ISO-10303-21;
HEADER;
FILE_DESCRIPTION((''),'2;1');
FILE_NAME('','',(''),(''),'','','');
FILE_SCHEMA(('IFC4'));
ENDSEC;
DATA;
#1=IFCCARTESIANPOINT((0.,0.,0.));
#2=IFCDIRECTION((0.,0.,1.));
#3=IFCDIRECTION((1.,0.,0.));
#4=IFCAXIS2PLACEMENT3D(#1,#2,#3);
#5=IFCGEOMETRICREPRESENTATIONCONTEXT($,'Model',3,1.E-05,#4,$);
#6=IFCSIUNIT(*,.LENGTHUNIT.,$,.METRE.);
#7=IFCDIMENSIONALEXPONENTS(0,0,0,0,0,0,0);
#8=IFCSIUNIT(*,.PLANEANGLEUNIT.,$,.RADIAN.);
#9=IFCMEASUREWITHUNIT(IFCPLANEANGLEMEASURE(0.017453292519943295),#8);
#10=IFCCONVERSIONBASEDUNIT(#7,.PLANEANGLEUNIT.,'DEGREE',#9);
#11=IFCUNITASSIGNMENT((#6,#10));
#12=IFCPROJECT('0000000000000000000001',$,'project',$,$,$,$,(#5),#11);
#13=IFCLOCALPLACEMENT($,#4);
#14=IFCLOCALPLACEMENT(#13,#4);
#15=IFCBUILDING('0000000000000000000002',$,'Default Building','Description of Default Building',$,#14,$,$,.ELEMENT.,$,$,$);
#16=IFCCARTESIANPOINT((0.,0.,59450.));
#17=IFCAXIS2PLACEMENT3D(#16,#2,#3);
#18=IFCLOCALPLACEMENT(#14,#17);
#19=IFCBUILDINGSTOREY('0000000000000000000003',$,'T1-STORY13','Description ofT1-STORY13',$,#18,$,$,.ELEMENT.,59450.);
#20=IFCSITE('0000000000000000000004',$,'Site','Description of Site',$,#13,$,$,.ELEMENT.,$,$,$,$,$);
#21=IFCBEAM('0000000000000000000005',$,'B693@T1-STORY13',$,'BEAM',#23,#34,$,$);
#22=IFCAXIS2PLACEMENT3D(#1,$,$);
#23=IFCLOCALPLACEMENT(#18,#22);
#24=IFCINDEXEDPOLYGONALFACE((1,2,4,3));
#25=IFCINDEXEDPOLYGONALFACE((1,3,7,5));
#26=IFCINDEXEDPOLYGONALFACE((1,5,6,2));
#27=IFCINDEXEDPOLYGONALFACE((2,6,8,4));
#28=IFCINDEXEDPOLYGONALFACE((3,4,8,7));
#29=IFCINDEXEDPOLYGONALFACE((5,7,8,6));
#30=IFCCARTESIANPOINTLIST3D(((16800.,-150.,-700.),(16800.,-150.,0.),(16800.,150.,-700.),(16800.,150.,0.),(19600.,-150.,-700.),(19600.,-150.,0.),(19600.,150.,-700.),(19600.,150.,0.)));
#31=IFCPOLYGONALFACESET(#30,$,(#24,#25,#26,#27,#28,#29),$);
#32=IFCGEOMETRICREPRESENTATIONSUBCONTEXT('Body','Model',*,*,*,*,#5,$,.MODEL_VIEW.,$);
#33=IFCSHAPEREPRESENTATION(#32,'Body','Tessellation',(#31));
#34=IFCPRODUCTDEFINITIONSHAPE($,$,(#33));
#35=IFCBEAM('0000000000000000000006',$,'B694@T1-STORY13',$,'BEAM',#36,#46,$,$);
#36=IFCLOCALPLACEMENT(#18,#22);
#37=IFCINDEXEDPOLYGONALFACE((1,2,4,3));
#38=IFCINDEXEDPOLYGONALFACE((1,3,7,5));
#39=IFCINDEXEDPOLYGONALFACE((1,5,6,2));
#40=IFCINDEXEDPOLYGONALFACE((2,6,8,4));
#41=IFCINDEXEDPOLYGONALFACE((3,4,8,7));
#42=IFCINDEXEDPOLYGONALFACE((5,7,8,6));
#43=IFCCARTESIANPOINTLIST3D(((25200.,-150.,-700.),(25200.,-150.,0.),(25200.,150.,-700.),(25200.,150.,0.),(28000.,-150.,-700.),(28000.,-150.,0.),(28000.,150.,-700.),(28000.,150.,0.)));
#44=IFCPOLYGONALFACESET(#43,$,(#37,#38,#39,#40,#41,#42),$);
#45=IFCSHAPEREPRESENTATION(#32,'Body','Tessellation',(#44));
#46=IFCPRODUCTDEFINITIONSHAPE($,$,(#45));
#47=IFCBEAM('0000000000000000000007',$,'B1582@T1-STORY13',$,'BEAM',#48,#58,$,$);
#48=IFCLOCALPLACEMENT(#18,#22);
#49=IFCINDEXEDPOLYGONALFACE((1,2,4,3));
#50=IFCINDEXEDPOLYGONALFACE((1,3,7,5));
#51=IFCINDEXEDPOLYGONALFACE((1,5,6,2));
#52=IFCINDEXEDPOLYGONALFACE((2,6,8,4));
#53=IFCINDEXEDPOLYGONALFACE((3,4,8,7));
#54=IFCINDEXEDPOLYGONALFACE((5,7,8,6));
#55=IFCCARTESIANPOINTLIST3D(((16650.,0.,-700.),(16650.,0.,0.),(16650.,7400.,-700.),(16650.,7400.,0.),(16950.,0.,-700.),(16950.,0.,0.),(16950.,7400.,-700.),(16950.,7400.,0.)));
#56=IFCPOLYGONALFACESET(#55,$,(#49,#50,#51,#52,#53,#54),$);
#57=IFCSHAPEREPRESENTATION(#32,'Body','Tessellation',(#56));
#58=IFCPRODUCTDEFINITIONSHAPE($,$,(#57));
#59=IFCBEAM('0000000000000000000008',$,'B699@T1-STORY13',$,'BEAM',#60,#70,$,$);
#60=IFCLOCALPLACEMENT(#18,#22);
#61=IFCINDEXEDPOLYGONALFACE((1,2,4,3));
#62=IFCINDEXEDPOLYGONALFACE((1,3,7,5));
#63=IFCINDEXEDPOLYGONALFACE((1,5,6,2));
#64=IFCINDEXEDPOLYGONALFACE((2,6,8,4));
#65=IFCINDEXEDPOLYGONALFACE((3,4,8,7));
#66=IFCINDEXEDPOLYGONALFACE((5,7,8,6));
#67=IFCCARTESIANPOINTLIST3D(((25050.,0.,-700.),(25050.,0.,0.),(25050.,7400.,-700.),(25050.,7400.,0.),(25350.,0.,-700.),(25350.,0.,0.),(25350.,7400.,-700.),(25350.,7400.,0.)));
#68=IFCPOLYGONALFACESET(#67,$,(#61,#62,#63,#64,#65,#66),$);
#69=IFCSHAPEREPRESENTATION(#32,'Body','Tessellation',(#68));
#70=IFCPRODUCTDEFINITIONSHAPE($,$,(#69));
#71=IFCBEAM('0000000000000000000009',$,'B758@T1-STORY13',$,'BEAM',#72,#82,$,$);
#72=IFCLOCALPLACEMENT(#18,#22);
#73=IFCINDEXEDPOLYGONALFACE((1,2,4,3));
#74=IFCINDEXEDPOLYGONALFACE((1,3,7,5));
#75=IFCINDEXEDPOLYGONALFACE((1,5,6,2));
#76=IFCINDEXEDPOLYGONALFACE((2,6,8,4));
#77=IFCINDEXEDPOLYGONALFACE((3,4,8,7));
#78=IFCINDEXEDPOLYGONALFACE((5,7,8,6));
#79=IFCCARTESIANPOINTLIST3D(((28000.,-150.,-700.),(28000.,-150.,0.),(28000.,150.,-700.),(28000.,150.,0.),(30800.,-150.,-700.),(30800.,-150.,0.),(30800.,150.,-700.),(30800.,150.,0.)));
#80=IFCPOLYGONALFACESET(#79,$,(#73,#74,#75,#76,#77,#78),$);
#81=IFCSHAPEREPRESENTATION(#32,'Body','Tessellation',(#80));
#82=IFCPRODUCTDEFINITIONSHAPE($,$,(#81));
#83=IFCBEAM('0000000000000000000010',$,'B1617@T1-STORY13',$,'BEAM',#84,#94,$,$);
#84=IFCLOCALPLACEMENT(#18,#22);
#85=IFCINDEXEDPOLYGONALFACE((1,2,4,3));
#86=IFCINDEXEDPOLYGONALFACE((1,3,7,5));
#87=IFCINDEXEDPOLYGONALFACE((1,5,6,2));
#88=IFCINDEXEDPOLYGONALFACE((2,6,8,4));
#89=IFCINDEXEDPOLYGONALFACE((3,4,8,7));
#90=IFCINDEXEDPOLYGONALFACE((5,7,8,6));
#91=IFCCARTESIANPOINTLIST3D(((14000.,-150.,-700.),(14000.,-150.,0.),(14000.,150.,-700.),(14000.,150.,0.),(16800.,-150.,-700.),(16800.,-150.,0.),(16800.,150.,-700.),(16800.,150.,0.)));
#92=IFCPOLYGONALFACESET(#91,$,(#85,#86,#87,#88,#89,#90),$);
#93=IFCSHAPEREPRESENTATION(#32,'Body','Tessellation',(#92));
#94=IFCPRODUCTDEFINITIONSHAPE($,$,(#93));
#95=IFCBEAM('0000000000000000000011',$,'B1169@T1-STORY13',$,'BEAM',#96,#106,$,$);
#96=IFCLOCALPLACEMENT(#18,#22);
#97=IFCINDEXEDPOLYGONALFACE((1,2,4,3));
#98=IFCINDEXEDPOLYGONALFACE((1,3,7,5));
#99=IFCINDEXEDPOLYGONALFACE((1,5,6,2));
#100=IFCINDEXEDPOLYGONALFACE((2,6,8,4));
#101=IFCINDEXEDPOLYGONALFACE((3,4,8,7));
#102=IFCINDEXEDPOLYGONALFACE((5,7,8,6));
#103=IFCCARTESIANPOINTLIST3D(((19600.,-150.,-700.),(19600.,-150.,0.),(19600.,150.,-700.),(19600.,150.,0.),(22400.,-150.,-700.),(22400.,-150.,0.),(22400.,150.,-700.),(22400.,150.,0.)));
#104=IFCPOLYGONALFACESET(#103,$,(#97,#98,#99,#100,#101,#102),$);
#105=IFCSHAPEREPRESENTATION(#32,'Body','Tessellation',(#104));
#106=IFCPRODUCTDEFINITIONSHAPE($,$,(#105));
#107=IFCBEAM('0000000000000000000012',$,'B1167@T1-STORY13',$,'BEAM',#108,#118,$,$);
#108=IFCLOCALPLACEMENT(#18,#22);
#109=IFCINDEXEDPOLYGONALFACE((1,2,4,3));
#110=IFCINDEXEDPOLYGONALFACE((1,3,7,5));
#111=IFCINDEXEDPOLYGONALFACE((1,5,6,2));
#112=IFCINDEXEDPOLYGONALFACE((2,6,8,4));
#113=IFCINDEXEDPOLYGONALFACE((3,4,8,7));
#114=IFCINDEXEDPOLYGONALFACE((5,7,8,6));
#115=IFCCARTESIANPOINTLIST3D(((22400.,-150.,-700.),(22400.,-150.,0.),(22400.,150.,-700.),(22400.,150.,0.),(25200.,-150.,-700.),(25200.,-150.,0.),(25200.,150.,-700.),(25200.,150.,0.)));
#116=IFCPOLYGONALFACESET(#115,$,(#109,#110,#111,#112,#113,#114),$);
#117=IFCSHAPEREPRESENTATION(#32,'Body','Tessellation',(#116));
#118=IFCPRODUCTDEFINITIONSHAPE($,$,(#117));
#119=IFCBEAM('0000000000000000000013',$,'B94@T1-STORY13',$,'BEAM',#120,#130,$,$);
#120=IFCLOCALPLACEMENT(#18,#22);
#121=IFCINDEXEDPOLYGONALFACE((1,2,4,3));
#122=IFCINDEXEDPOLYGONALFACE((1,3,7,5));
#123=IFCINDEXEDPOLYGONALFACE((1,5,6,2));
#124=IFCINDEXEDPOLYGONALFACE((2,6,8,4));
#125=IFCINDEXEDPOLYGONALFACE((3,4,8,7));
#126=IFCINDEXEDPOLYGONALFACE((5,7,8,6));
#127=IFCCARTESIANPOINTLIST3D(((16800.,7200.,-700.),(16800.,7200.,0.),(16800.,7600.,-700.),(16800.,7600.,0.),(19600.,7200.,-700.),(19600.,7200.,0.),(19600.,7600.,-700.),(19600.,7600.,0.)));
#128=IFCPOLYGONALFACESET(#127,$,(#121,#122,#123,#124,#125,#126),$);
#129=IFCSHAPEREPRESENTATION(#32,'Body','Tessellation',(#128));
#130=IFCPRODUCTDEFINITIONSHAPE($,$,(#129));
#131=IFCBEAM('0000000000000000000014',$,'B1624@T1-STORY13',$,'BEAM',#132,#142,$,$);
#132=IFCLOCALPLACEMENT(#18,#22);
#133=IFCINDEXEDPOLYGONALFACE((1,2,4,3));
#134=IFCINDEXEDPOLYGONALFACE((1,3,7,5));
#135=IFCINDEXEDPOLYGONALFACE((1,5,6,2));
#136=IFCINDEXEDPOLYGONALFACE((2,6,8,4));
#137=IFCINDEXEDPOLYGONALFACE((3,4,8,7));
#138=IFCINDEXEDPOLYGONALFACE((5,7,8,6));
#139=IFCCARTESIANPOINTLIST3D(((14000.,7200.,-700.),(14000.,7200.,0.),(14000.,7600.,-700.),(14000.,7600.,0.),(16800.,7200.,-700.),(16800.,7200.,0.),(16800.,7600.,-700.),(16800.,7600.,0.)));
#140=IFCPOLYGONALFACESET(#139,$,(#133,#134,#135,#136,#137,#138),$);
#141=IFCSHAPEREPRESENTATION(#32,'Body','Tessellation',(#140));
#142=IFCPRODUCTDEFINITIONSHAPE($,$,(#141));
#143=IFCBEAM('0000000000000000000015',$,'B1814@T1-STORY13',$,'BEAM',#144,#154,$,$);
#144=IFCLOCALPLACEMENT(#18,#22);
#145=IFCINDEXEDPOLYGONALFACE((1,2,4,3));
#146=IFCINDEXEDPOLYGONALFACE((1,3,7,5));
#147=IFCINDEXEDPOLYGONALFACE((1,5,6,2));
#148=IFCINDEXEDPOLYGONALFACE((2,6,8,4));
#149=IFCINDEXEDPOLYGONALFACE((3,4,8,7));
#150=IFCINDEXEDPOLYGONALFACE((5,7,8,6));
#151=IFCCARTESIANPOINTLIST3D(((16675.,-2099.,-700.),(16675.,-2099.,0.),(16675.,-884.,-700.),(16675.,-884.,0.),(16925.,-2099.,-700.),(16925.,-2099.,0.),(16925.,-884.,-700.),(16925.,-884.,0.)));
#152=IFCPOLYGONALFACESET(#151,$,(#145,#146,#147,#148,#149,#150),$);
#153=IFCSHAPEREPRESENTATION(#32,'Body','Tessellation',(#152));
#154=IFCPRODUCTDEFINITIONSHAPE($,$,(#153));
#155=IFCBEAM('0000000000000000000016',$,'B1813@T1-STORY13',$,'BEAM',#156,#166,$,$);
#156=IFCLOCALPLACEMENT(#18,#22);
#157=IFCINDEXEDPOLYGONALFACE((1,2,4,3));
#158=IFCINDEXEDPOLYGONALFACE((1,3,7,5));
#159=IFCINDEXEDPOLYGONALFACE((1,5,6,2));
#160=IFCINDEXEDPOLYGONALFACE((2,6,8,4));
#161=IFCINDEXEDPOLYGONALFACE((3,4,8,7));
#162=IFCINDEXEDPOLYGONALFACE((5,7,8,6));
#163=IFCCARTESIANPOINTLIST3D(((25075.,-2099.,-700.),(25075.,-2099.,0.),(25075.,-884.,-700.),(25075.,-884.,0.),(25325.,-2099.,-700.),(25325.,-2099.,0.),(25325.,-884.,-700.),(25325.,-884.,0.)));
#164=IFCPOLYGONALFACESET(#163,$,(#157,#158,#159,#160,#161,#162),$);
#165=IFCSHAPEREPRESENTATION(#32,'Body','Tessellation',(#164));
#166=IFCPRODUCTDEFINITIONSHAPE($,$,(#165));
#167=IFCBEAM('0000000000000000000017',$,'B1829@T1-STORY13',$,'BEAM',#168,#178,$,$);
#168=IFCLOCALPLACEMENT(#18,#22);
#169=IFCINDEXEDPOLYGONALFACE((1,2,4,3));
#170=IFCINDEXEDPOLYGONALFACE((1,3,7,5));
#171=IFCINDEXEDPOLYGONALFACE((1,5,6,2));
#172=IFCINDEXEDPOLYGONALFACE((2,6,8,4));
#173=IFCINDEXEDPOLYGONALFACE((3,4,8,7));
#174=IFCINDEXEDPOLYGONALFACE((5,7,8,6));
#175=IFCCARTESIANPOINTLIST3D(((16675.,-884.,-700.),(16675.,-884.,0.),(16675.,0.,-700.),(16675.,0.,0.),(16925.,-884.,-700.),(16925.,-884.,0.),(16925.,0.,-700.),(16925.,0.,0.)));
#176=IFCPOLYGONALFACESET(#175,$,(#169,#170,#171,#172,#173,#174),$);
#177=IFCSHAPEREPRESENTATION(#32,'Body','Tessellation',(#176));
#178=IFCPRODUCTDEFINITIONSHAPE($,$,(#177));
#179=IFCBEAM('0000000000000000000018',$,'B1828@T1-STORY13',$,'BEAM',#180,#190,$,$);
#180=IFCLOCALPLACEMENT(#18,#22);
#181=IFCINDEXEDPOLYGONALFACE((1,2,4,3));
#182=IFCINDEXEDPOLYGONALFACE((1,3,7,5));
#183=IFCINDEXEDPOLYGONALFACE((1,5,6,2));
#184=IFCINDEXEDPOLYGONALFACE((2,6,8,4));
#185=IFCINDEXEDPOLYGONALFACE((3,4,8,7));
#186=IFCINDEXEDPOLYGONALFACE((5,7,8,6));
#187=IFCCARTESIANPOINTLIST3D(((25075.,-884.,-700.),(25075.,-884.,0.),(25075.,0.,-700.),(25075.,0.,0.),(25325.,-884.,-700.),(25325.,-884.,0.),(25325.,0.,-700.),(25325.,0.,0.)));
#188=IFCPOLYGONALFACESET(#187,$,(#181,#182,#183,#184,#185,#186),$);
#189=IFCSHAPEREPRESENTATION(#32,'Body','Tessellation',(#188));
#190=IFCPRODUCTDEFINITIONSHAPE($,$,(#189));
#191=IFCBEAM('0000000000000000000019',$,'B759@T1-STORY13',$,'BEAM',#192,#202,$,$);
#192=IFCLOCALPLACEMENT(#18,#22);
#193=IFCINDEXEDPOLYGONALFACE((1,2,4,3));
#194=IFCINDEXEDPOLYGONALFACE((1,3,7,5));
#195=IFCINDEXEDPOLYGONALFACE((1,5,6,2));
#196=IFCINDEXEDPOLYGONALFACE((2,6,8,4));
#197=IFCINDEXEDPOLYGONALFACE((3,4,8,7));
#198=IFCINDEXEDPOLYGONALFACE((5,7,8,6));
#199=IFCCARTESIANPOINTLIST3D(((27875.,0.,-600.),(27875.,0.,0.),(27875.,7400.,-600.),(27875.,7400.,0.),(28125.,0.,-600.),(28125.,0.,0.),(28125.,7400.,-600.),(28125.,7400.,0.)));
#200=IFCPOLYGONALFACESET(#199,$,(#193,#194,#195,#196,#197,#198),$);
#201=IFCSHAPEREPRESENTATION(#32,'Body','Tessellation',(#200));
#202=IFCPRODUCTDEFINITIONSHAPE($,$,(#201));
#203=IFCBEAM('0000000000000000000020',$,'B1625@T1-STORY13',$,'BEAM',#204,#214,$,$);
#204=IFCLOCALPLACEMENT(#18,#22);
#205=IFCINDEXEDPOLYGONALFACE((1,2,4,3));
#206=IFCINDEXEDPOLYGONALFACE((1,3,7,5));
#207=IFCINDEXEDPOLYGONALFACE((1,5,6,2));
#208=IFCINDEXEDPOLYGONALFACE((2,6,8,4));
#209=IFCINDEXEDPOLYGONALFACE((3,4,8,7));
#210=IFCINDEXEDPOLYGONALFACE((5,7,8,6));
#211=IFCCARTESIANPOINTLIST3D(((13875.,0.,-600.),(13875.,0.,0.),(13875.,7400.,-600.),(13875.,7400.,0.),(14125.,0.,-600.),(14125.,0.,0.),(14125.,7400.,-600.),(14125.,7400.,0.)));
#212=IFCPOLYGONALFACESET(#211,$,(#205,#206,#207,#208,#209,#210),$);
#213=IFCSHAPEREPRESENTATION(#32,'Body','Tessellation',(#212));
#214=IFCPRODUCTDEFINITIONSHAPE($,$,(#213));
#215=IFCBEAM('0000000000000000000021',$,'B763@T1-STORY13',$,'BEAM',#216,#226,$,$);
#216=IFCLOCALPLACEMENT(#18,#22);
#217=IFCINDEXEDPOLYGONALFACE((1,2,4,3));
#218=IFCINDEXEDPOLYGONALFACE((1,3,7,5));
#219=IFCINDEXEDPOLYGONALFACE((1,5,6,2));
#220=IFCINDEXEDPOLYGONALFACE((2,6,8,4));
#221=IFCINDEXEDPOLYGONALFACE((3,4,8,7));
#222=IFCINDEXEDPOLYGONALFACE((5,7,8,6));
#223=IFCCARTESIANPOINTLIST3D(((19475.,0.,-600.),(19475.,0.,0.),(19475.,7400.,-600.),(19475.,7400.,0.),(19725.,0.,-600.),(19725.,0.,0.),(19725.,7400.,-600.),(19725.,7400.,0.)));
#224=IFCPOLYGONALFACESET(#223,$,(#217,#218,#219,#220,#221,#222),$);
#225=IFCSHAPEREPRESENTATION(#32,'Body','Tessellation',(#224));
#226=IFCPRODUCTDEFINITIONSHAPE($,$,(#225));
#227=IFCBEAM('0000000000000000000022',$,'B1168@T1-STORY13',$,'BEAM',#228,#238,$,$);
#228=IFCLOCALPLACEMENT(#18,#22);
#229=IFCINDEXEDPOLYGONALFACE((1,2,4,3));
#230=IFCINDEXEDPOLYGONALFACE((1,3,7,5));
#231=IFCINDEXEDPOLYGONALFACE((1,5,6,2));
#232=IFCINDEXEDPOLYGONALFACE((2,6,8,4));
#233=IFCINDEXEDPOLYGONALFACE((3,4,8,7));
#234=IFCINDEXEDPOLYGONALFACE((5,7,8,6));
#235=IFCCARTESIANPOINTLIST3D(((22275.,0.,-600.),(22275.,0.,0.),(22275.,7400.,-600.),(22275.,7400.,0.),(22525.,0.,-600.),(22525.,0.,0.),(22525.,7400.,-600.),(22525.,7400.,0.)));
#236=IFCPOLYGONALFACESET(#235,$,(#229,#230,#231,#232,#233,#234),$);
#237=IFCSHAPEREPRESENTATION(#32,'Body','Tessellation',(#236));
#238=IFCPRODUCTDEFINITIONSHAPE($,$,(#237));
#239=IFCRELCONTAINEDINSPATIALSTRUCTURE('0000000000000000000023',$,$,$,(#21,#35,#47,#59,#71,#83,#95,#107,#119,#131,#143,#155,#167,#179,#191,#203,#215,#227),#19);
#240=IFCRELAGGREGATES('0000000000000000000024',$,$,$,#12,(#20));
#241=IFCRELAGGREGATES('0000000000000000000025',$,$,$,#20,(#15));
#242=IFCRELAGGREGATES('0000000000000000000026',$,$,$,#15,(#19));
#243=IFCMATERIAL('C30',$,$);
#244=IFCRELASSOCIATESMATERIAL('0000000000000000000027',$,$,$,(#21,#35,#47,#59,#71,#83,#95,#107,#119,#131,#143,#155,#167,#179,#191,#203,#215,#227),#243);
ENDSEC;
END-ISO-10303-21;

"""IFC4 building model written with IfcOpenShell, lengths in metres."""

from ifc_helpers import new_model, entity, si_unit, converted_unit, frame, origin_with_axes, place, context, subcontext, project, spatial, rectangle, extrude, material, element, save


model = new_model("IFC4")

# Units and contexts
model_context = context("Model", 3, precision=1e-05, world=origin_with_axes())
body_context = subcontext(model_context, "Body", "Model", "MODEL_VIEW")
ifc_project = project(units=[si_unit("LENGTHUNIT", "METRE"), converted_unit("PLANEANGLEUNIT", "DEGREE", entity("IfcPlaneAngleMeasure", 0.017453292519943295), si_unit("PLANEANGLEUNIT", "RADIAN"), dimensions=[0, 0, 0, 0, 0, 0, 0])], contexts=[model_context])

# Site, building, storey
site_placement = place(None, origin_with_axes())
site = spatial("IfcSite", under=ifc_project, at=site_placement, Name="Site", Description="Description of Site", CompositionType="ELEMENT")
building_placement = place(site_placement, origin_with_axes())
building = spatial("IfcBuilding", under=site, at=building_placement, Name="Default Building", Description="Description of Default Building", CompositionType="ELEMENT")
storey_placement = place(building_placement, frame((0.0, 0.0, 59450.0), z_axis=(0.0, 0.0, 1.0), x_axis=(1.0, 0.0, 0.0)))
storey = spatial("IfcBuildingStorey", under=building, at=storey_placement, Name="T1-STORY13", Description="Description ofT1-STORY13", CompositionType="ELEMENT", Elevation=59450.0)

# Beams
ifc_material_1 = material(Name="C30")
for number, where, z_axis, x_axis, name in (
    (1, (16800.0, 0.0, -350.0), (1.0, 0.0, 0.0), (0.0, 1.0, 0.0), "B693@T1-STORY13"),
    (2, (25200.0, 0.0, -350.0), (1.0, 0.0, 0.0), (0.0, 1.0, 0.0), "B694@T1-STORY13"),
):
    element("IfcBeam", number, at=place(storey_placement, frame(where, z_axis=z_axis, x_axis=x_axis)), inside=storey, material=ifc_material_1, Name=name, ObjectType="BEAM", context=body_context, shape_type="SweptSolid", body=[
        extrude(rectangle(XDim=300.0, YDim=700.0), origin_with_axes(), (0.0, 0.0, 1.0), 2800.0),
    ])
for number, where, z_axis, x_axis, name in (
    (3, (16800.0, 0.0, -350.0), (0.0, 1.0, 0.0), (-1.0, 0.0, 0.0), "B1582@T1-STORY13"),
    (4, (25200.0, 0.0, -350.0), (0.0, 1.0, 0.0), (-1.0, 0.0, 0.0), "B699@T1-STORY13"),
):
    element("IfcBeam", number, at=place(storey_placement, frame(where, z_axis=z_axis, x_axis=x_axis)), inside=storey, material=ifc_material_1, Name=name, ObjectType="BEAM", context=body_context, shape_type="SweptSolid", body=[
        extrude(rectangle(XDim=300.0, YDim=700.0), origin_with_axes(), (0.0, 0.0, 1.0), 7400.0),
    ])
for number, where, z_axis, x_axis, name in (
    (5, (28000.0, 0.0, -350.0), (1.0, 0.0, 0.0), (0.0, 1.0, 0.0), "B758@T1-STORY13"),
    (6, (14000.0, 0.0, -350.0), (1.0, 0.0, 0.0), (0.0, 1.0, 0.0), "B1617@T1-STORY13"),
    (7, (19600.0, 0.0, -350.0), (1.0, 0.0, 0.0), (0.0, 1.0, 0.0), "B1169@T1-STORY13"),
    (8, (22400.0, 0.0, -350.0), (1.0, 0.0, 0.0), (0.0, 1.0, 0.0), "B1167@T1-STORY13"),
):
    element("IfcBeam", number, at=place(storey_placement, frame(where, z_axis=z_axis, x_axis=x_axis)), inside=storey, material=ifc_material_1, Name=name, ObjectType="BEAM", context=body_context, shape_type="SweptSolid", body=[
        extrude(rectangle(XDim=300.0, YDim=700.0), origin_with_axes(), (0.0, 0.0, 1.0), 2800.0),
    ])
for number, where, z_axis, x_axis, name in (
    (9, (16800.0, 7400.0, -350.0), (1.0, 0.0, 0.0), (0.0, 1.0, 0.0), "B94@T1-STORY13"),
    (10, (14000.0, 7400.0, -350.0), (1.0, 0.0, 0.0), (0.0, 1.0, 0.0), "B1624@T1-STORY13"),
):
    element("IfcBeam", number, at=place(storey_placement, frame(where, z_axis=z_axis, x_axis=x_axis)), inside=storey, material=ifc_material_1, Name=name, ObjectType="BEAM", context=body_context, shape_type="SweptSolid", body=[
        extrude(rectangle(XDim=400.0, YDim=700.0), origin_with_axes(), (0.0, 0.0, 1.0), 2800.0),
    ])
for number, where, z_axis, x_axis, name in (
    (11, (16800.0, -2099.0, -350.0), (0.0, 1.0, 0.0), (-1.0, 0.0, 0.0), "B1814@T1-STORY13"),
    (12, (25200.0, -2099.0, -350.0), (0.0, 1.0, 0.0), (-1.0, 0.0, 0.0), "B1813@T1-STORY13"),
):
    element("IfcBeam", number, at=place(storey_placement, frame(where, z_axis=z_axis, x_axis=x_axis)), inside=storey, material=ifc_material_1, Name=name, ObjectType="BEAM", context=body_context, shape_type="SweptSolid", body=[
        extrude(rectangle(XDim=250.0, YDim=700.0), origin_with_axes(), (0.0, 0.0, 1.0), 1215.0),
    ])
for number, where, z_axis, x_axis, name in (
    (13, (16800.0, -884.0, -350.0), (0.0, 1.0, 0.0), (-1.0, 0.0, 0.0), "B1829@T1-STORY13"),
    (14, (25200.0, -884.0, -350.0), (0.0, 1.0, 0.0), (-1.0, 0.0, 0.0), "B1828@T1-STORY13"),
):
    element("IfcBeam", number, at=place(storey_placement, frame(where, z_axis=z_axis, x_axis=x_axis)), inside=storey, material=ifc_material_1, Name=name, ObjectType="BEAM", context=body_context, shape_type="SweptSolid", body=[
        extrude(rectangle(XDim=250.0, YDim=700.0), origin_with_axes(), (0.0, 0.0, 1.0), 884.0),
    ])
for number, where, z_axis, x_axis, name in (
    (15, (28000.0, 0.0, -300.0), (0.0, 1.0, 0.0), (-1.0, 0.0, 0.0), "B759@T1-STORY13"),
    (16, (14000.0, 0.0, -300.0), (0.0, 1.0, 0.0), (-1.0, 0.0, 0.0), "B1625@T1-STORY13"),
    (17, (19600.0, 0.0, -300.0), (0.0, 1.0, 0.0), (-1.0, 0.0, 0.0), "B763@T1-STORY13"),
    (18, (22400.0, 0.0, -300.0), (0.0, 1.0, 0.0), (-1.0, 0.0, 0.0), "B1168@T1-STORY13"),
):
    element("IfcBeam", number, at=place(storey_placement, frame(where, z_axis=z_axis, x_axis=x_axis)), inside=storey, material=ifc_material_1, Name=name, ObjectType="BEAM", context=body_context, shape_type="SweptSolid", body=[
        extrude(rectangle(XDim=250.0, YDim=600.0), origin_with_axes(), (0.0, 0.0, 1.0), 7400.0),
    ])

save(model, "model.ifc")
